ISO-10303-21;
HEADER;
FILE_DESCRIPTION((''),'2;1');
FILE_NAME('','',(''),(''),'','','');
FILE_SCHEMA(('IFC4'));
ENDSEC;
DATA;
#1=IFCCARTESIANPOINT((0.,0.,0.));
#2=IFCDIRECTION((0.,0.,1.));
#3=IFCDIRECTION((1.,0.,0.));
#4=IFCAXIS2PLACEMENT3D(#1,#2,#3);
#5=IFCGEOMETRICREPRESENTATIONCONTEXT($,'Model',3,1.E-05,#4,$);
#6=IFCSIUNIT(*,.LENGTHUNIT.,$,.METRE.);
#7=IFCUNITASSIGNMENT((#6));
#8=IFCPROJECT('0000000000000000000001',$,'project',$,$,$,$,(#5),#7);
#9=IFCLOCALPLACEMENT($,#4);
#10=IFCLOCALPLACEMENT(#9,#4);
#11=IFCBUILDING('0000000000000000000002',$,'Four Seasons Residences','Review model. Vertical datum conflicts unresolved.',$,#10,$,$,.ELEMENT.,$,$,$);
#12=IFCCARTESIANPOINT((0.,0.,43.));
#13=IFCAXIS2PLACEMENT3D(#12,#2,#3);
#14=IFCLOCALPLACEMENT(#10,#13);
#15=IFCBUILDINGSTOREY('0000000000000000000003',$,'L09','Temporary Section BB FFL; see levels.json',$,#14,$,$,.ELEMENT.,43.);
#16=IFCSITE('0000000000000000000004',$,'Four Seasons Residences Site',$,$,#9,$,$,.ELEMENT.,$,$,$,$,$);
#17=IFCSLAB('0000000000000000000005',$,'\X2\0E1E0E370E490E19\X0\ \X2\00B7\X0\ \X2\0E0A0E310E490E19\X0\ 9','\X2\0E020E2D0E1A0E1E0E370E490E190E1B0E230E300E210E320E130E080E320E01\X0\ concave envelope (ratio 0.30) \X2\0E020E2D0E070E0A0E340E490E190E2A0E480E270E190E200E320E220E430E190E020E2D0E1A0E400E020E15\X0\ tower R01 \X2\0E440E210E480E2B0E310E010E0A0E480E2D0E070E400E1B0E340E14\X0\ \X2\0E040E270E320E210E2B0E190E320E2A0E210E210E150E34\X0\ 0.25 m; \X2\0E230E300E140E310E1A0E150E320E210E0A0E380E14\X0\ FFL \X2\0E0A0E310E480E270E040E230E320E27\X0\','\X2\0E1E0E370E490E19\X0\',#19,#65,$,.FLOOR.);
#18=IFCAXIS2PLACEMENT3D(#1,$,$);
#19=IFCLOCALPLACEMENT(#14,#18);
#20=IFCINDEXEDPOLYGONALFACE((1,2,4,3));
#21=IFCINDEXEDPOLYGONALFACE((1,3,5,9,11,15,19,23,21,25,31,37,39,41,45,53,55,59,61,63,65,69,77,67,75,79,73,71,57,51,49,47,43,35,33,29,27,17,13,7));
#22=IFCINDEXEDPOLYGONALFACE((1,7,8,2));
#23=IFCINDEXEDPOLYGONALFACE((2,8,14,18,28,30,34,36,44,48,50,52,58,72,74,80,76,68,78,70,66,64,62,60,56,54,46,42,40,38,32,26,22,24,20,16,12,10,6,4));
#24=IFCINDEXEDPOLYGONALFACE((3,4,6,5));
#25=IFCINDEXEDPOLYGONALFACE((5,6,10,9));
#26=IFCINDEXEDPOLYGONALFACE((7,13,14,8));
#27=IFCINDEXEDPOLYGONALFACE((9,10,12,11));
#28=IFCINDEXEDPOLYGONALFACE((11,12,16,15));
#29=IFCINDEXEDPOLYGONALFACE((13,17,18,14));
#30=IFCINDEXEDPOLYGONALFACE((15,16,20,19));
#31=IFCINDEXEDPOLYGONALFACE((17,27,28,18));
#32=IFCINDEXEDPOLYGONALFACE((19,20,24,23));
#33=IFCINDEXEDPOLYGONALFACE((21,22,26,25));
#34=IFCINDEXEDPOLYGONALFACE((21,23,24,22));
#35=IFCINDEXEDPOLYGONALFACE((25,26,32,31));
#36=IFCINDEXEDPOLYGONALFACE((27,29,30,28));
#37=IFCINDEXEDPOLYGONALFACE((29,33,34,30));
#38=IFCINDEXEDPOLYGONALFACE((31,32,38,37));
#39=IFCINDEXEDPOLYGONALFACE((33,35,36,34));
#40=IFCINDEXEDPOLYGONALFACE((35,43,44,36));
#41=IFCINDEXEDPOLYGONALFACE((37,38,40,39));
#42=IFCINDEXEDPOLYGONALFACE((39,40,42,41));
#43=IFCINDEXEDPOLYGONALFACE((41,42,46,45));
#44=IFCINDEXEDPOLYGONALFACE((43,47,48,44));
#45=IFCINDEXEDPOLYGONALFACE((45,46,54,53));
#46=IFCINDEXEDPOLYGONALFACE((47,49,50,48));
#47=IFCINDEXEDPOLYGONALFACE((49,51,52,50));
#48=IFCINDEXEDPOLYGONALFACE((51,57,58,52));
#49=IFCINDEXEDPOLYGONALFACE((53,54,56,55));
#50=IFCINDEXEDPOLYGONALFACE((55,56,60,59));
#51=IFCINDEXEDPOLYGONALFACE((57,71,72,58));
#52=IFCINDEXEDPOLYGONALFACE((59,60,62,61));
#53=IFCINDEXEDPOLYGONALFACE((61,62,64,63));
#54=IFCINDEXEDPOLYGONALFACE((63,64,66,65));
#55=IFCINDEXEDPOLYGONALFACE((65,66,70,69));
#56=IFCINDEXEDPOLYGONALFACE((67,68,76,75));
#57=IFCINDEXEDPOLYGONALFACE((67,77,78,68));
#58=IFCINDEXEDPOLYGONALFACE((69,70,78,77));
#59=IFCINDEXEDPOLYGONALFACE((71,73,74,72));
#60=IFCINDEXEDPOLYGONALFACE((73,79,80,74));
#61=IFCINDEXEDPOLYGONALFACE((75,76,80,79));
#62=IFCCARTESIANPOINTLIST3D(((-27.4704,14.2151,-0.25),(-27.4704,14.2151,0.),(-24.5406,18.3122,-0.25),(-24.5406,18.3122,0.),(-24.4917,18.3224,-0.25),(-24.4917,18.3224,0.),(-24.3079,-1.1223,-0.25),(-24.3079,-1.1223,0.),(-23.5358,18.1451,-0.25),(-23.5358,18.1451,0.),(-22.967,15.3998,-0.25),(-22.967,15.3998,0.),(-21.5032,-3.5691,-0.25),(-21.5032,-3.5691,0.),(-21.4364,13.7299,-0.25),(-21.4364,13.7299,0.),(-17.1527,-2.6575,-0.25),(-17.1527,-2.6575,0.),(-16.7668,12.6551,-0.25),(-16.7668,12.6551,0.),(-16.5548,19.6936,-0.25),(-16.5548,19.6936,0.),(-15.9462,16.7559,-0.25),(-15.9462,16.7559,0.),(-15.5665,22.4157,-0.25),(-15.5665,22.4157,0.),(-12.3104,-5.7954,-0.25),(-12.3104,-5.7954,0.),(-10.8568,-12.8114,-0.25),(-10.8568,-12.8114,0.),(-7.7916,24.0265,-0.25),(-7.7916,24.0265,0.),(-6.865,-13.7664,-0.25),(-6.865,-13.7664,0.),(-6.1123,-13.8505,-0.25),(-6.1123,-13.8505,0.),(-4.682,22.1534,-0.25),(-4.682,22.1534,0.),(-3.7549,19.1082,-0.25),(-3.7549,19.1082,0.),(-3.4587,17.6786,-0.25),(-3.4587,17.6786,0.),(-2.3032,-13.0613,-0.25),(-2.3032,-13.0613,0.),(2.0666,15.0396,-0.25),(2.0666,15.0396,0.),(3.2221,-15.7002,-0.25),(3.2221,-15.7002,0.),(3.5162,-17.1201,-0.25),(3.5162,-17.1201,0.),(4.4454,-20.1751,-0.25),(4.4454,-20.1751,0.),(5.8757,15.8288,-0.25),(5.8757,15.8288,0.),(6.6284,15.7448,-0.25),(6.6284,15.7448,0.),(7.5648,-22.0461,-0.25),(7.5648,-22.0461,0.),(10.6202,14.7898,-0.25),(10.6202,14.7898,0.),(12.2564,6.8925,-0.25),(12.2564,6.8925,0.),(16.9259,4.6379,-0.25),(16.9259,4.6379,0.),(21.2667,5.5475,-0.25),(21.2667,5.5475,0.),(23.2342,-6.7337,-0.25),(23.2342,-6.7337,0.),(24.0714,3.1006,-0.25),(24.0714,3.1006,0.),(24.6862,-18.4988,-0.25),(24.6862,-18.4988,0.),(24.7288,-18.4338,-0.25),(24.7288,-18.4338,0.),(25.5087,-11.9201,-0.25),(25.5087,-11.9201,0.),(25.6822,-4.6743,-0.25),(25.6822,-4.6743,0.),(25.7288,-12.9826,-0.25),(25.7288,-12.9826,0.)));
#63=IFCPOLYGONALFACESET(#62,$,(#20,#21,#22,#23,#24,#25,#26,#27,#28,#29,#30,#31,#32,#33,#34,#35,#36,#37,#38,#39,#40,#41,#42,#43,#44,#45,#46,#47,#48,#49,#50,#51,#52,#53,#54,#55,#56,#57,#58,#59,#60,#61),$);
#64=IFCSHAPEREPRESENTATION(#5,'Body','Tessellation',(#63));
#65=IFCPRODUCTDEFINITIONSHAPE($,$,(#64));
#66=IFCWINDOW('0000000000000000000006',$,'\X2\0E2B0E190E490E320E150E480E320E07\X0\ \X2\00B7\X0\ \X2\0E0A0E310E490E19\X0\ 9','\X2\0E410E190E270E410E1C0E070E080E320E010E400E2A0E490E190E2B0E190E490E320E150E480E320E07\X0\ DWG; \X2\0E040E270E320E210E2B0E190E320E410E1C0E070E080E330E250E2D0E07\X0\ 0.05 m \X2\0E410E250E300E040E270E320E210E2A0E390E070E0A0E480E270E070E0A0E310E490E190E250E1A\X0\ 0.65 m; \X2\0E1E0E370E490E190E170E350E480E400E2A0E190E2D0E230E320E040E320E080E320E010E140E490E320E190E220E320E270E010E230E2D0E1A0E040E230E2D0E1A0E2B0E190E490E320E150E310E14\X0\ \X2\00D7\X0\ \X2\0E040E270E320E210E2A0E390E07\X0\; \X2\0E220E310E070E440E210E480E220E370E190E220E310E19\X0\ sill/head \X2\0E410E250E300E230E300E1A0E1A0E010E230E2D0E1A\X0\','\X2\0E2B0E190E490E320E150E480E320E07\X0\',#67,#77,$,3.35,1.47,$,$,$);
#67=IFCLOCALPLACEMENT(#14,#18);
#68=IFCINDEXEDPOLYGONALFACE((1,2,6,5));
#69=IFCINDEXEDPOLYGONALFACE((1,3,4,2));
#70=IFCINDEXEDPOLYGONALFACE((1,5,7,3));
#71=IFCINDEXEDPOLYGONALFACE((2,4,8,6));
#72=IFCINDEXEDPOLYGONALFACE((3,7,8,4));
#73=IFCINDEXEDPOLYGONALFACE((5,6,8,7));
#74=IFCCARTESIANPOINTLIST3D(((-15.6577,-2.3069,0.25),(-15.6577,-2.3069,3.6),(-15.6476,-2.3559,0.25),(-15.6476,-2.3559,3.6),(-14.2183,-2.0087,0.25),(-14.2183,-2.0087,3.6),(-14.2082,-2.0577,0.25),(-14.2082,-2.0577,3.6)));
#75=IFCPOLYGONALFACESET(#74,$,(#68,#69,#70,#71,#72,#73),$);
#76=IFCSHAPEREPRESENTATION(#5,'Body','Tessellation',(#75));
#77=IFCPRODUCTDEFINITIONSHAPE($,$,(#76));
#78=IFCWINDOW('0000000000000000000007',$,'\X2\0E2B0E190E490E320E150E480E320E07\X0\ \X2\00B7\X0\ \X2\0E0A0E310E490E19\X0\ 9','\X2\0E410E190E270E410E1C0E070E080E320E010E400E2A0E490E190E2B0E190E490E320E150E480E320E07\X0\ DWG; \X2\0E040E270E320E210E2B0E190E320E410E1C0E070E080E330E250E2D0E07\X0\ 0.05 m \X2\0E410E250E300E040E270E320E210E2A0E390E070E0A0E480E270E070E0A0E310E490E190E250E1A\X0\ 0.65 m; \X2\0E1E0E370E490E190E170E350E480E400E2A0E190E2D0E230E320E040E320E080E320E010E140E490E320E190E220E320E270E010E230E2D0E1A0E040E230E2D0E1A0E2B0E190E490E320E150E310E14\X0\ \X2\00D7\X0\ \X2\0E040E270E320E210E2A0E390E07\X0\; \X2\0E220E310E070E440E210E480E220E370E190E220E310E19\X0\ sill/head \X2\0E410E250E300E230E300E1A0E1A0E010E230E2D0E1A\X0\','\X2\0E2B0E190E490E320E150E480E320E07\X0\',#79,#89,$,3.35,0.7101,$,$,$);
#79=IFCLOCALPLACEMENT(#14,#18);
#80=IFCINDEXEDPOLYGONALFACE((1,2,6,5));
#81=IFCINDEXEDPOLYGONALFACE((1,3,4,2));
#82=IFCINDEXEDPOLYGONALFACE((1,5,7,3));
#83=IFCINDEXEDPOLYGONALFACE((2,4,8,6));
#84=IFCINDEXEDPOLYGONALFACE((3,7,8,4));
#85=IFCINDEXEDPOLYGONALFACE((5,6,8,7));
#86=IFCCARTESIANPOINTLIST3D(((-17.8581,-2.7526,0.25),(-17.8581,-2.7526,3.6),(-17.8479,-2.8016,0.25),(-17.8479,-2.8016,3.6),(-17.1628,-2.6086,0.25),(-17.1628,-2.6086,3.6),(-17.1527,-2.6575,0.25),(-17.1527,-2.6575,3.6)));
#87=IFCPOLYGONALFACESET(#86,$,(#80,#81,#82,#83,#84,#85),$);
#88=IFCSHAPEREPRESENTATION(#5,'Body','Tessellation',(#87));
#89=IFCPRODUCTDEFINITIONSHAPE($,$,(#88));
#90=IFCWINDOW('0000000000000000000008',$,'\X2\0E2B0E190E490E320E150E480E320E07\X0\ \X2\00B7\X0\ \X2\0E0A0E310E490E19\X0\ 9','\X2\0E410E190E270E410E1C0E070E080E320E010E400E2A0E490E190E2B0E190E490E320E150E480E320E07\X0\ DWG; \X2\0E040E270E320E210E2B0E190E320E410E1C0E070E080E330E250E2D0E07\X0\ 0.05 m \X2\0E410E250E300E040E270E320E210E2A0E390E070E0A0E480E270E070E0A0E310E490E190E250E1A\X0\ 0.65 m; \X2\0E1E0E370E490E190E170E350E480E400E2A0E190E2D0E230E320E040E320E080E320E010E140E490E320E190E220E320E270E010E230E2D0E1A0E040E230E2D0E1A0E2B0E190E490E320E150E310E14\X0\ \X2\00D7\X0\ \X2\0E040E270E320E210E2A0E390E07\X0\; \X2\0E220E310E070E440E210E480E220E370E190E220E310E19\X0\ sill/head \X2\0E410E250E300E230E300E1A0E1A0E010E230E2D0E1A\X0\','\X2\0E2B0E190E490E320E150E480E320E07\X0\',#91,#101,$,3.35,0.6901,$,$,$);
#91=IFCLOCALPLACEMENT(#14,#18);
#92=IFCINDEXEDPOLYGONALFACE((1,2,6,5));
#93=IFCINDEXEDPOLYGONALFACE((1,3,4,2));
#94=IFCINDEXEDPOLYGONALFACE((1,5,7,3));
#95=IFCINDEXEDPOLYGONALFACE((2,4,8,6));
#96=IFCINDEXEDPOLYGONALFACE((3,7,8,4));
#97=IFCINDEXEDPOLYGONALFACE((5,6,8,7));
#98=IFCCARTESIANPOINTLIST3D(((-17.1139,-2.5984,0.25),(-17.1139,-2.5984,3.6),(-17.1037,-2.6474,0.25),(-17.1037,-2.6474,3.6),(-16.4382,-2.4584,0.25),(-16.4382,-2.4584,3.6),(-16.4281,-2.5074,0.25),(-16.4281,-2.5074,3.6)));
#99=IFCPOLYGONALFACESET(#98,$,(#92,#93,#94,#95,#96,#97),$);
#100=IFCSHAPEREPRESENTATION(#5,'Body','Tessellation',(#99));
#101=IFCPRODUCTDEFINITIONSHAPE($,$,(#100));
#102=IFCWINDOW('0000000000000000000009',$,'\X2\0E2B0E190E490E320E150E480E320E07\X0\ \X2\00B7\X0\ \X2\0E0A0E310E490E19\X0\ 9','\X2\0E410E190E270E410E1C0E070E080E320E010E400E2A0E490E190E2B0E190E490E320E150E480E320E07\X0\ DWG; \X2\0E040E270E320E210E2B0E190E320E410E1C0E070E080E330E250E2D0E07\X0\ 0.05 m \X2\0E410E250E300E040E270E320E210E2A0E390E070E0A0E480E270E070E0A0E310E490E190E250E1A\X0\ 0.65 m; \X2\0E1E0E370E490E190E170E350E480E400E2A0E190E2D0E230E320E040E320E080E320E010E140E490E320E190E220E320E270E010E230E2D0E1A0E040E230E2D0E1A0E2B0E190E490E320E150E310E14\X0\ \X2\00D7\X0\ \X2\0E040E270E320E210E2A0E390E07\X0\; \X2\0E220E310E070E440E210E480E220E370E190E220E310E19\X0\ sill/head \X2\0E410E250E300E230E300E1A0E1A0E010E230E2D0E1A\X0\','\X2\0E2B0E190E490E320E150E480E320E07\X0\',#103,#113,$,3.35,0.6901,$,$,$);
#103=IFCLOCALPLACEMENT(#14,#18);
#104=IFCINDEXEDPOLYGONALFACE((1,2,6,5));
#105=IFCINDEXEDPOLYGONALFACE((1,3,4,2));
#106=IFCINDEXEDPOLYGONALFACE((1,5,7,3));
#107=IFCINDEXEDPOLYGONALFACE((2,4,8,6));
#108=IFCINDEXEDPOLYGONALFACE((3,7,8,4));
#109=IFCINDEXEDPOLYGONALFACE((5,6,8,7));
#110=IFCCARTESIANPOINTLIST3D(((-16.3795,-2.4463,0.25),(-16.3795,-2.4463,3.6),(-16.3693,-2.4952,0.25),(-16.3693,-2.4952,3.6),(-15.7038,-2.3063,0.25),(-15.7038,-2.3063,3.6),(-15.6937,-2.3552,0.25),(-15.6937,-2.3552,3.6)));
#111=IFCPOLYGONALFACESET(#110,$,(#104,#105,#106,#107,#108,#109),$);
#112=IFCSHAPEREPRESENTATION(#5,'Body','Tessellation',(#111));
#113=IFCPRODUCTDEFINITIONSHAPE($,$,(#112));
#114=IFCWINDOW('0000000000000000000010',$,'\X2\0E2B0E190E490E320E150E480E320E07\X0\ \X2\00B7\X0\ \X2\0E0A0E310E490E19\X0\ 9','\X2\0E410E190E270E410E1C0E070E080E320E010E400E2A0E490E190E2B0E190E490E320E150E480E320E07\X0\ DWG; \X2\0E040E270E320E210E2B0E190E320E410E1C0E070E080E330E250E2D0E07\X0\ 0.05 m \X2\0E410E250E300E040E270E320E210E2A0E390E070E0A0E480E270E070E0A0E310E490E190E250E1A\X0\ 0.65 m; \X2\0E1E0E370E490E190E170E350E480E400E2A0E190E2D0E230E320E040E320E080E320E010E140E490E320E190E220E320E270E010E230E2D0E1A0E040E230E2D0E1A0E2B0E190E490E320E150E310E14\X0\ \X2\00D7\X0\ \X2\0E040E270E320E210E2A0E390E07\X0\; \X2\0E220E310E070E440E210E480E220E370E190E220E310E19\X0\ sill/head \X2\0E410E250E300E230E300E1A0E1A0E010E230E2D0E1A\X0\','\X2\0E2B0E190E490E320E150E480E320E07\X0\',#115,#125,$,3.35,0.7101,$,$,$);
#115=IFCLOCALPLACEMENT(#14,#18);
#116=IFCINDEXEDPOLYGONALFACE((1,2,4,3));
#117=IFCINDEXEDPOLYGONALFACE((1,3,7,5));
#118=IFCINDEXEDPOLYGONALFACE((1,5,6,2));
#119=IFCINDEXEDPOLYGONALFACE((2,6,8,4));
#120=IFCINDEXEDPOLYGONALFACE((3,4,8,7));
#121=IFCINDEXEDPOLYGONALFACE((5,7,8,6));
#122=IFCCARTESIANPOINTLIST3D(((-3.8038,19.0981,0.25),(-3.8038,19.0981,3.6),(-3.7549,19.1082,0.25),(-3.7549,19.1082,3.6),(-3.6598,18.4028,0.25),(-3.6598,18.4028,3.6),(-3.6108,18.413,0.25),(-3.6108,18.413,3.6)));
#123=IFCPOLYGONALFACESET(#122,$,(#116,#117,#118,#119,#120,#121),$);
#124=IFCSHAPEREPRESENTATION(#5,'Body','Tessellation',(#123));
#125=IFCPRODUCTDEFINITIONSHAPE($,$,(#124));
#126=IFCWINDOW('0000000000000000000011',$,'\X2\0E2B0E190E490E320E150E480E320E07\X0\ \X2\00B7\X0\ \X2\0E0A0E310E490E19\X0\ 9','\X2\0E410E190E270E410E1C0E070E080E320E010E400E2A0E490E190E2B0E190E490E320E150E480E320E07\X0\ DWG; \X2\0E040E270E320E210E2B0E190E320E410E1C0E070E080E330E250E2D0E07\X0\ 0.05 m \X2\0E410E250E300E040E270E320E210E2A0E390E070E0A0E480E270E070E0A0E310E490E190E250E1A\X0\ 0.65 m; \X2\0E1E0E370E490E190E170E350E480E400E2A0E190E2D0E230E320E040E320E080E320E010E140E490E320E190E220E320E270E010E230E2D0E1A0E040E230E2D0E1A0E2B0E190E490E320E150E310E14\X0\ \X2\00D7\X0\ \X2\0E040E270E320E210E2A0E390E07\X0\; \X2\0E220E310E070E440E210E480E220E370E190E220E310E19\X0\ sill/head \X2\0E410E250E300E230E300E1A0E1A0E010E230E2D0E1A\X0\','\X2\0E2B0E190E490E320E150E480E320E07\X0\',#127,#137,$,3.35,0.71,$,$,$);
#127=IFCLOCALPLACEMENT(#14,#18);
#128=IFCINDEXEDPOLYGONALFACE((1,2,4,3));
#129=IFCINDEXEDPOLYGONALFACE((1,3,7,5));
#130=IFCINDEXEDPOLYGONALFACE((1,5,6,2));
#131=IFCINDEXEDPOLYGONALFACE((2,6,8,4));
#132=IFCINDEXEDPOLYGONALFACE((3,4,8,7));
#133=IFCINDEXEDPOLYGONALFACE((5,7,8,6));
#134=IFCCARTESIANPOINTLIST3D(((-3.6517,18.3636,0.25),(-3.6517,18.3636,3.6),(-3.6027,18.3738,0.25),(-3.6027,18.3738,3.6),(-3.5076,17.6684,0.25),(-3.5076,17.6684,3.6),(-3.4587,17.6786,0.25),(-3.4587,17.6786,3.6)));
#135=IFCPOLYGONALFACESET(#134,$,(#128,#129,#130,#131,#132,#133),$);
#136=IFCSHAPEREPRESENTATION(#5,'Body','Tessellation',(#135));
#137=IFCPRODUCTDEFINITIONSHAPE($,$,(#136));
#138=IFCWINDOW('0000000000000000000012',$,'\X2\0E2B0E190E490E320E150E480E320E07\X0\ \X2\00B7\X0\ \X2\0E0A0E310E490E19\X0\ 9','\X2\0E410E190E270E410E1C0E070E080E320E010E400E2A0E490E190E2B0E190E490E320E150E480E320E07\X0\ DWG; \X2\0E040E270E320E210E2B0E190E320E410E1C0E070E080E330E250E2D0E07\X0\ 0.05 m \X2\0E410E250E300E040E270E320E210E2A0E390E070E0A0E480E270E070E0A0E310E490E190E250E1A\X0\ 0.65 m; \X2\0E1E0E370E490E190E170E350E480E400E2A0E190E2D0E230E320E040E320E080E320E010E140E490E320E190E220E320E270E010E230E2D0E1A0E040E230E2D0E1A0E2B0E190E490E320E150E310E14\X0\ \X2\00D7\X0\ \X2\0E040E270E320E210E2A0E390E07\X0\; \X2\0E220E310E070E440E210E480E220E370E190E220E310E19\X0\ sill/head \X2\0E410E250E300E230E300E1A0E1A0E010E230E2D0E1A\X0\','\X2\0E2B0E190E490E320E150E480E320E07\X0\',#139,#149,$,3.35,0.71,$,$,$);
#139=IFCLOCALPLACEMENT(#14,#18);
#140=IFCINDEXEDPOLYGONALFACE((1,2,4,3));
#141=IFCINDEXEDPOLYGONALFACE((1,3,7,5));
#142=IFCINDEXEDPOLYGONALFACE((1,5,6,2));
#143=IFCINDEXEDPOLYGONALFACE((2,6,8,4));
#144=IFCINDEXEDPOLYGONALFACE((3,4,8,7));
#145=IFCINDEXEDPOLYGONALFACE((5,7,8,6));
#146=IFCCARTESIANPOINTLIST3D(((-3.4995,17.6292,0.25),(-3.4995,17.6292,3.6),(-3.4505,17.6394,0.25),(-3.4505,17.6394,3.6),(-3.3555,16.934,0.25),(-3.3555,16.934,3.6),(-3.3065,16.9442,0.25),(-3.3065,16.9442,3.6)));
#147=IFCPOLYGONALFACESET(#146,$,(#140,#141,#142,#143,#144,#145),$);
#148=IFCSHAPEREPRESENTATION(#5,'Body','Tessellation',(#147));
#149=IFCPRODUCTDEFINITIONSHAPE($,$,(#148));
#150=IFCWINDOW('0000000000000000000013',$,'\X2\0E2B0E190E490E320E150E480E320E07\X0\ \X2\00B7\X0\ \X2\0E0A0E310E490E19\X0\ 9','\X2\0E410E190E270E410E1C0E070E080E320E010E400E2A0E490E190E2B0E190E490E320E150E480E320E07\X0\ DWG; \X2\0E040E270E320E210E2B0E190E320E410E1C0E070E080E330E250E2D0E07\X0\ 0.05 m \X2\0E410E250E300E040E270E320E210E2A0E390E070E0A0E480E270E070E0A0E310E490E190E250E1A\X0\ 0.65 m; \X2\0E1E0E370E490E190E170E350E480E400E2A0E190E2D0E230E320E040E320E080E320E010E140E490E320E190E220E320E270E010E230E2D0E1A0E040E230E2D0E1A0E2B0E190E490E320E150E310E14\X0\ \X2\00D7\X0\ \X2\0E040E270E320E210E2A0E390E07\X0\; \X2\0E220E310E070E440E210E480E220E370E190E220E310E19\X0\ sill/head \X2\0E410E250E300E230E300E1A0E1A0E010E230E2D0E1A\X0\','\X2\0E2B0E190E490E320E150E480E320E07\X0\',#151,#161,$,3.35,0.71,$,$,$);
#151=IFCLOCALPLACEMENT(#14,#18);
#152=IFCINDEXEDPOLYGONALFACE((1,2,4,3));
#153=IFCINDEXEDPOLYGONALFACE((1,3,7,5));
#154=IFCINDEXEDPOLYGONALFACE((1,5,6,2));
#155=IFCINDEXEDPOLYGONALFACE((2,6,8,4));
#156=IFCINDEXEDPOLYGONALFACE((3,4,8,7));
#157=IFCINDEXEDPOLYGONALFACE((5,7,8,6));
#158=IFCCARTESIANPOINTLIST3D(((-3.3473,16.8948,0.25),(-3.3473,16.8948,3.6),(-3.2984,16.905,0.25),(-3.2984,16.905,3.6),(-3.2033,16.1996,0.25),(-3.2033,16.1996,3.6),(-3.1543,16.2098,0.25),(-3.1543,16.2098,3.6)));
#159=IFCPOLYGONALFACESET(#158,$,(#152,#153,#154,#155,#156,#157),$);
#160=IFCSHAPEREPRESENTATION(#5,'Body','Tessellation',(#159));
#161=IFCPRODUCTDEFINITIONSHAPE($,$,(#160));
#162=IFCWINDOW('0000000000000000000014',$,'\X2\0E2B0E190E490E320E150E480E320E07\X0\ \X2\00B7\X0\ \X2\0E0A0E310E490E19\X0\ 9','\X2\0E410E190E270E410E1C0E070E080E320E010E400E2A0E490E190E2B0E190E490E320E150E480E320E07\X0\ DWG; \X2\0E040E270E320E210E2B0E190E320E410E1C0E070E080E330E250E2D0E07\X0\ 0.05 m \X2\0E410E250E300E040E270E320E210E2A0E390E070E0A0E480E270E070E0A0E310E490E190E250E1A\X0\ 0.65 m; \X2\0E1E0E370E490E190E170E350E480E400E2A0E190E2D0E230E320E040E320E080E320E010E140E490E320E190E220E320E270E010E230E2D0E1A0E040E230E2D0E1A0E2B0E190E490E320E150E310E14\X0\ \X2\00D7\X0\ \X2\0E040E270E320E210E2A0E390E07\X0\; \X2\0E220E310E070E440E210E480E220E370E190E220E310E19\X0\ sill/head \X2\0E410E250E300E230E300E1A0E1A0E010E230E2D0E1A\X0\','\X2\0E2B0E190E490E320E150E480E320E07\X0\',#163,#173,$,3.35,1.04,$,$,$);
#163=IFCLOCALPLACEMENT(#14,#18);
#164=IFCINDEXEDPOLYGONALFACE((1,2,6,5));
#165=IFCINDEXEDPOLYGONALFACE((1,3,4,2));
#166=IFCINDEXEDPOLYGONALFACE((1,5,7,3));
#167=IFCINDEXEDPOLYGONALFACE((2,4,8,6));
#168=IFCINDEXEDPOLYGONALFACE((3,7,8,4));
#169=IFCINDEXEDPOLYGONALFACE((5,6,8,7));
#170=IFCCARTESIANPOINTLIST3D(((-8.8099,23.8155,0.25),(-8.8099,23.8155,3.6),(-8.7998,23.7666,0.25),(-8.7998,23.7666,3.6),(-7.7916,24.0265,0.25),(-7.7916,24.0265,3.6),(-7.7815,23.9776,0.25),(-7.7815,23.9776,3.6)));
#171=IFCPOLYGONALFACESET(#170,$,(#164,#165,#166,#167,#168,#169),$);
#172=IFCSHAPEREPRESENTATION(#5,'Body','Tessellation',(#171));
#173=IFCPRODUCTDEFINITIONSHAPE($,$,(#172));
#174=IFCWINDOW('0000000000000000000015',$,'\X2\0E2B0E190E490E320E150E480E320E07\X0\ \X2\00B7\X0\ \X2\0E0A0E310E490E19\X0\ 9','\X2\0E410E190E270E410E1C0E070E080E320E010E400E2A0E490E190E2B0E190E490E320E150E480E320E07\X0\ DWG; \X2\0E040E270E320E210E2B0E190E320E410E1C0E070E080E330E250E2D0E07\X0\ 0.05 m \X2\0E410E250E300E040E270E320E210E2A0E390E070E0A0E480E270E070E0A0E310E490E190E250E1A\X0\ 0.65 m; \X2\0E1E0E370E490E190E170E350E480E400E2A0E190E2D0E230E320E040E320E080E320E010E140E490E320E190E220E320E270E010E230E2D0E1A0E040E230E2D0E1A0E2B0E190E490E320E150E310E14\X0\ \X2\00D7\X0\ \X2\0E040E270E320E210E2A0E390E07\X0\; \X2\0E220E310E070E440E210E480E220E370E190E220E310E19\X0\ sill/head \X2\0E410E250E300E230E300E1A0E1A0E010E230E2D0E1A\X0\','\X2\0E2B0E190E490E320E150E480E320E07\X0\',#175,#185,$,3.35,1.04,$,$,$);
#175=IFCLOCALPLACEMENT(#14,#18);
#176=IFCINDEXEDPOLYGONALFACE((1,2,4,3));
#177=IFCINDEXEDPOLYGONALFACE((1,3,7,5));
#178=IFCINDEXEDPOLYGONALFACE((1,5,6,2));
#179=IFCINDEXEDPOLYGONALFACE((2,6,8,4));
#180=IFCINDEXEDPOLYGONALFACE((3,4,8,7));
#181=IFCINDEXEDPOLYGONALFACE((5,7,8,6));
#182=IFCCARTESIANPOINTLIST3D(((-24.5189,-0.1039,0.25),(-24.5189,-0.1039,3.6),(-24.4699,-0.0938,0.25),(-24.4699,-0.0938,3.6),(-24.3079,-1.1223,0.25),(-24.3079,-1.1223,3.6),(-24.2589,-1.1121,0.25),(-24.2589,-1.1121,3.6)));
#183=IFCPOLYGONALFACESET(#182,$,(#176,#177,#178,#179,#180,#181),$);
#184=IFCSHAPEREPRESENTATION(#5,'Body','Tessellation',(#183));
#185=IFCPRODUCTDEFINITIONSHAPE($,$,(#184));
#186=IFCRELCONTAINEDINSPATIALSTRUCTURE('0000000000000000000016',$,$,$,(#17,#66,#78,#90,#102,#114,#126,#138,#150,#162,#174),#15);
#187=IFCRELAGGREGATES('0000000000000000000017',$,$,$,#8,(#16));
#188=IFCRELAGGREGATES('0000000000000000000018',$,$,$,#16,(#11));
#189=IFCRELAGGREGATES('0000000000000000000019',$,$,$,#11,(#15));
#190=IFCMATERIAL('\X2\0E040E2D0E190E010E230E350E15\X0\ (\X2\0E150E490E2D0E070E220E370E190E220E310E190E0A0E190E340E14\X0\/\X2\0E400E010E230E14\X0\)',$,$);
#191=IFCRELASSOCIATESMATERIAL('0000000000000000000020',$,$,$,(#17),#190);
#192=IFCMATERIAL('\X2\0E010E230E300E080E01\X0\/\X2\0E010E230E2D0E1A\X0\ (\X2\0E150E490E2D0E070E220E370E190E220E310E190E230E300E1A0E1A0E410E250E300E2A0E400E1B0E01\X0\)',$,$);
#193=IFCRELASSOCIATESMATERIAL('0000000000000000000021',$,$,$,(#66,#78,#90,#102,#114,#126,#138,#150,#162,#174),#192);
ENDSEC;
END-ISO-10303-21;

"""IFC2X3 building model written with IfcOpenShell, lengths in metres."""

from ifc_helpers import new_model, si_unit, frame, origin_with_axes, place, context, project, spatial, polyline, outline, extrude, material, element, save


model = new_model("IFC2X3")

# Units and contexts
model_context = context("Model", 3, precision=1e-05, world=origin_with_axes())
ifc_project = project(units=[si_unit("LENGTHUNIT", "METRE")], contexts=[model_context])

# Site, building, storey
site_placement = place(None, origin_with_axes())
site = spatial("IfcSite", under=ifc_project, at=site_placement, Name="Four Seasons Residences Site", CompositionType="ELEMENT")
building_placement = place(site_placement, origin_with_axes())
building = spatial("IfcBuilding", under=site, at=building_placement, Name="Four Seasons Residences", Description="Review model. Vertical datum conflicts unresolved.", CompositionType="ELEMENT")
storey_placement = place(building_placement, frame((0.0, 0.0, 43.0), z_axis=(0.0, 0.0, 1.0), x_axis=(1.0, 0.0, 0.0)))
storey = spatial("IfcBuildingStorey", under=building, at=storey_placement, Name="L09", Description="Temporary Section BB FFL; see levels.json", CompositionType="ELEMENT", Elevation=43.0)

# Slab
ifc_material_1 = material(Name="คอนกรีต (ต้องยืนยันชนิด/เกรด)")
slab_placement = place(storey_placement, origin_with_axes())
element("IfcSlab", 1, at=slab_placement, inside=storey, material=ifc_material_1, Name="พื้น · ชั้น 9", Description="ขอบพื้นประมาณจาก concave envelope (ratio 0.30) ของชิ้นส่วนภายในขอบเขต tower R01 ไม่หักช่องเปิด ความหนาสมมติ 0.25 m; ระดับตามชุด FFL ชั่วคราว", ObjectType="พื้น", PredefinedType="FLOOR", context=model_context, shape_type="SweptSolid", body=[
    extrude(outline(polyline([(-27.4704, 14.2151), (-24.5406, 18.3122), (-24.4917, 18.3224), (-23.5358, 18.1451), (-22.967, 15.3998), (-21.4364, 13.7299), (-16.7668, 12.6551), (-15.9462, 16.7559), (-16.5548, 19.6936), (-15.5665, 22.4157), (-7.7916, 24.0265), (-4.682, 22.1534), (-3.7549, 19.1082), (-3.4587, 17.6786), (2.0666, 15.0396), (5.8757, 15.8288), (6.6284, 15.7448), (10.6202, 14.7898), (12.2564, 6.8925), (16.9259, 4.6379), (21.2667, 5.5475), (24.0714, 3.1006), (25.6822, -4.6743), (23.2342, -6.7337), (25.5087, -11.9201), (25.7288, -12.9826), (24.7288, -18.4338), (24.6862, -18.4988), (7.5648, -22.0461), (4.4454, -20.1751), (3.5162, -17.1201), (3.2221, -15.7002), (-2.3032, -13.0613), (-6.1123, -13.8505), (-6.865, -13.7664), (-10.8568, -12.8114), (-12.3104, -5.7954), (-17.1527, -2.6575), (-21.5032, -3.5691), (-24.3079, -1.1223), (-27.4704, 14.2151)])), frame((0.0, 0.0, -0.25), z_axis=(0.0, 0.0, 1.0), x_axis=(1.0, 0.0, 0.0)), (0.0, 0.0, 1.0), 0.25),
])

# Windows
ifc_material_2 = material(Name="กระจก/กรอบ (ต้องยืนยันระบบและสเปก)")
window_1_placement = place(storey_placement, origin_with_axes())
element("IfcWindow", 2, at=window_1_placement, inside=storey, material=ifc_material_2, Name="หน้าต่าง · ชั้น 9", Description="แนวแผงจากเส้นหน้าต่าง DWG; ความหนาแผงจำลอง 0.05 m และความสูงช่วงชั้นลบ 0.65 m; พื้นที่เสนอราคาจากด้านยาวกรอบครอบหน้าตัด × ความสูง; ยังไม่ยืนยัน sill/head และระบบกรอบ", ObjectType="หน้าต่าง", OverallHeight=3.35, OverallWidth=1.47, context=model_context, shape_type="SweptSolid", body=[
    extrude(outline(polyline([(-14.2183, -2.0087), (-14.2082, -2.0577), (-15.6476, -2.3559), (-15.6577, -2.3069), (-14.2183, -2.0087)])), frame((0.0, 0.0, 0.25), z_axis=(0.0, 0.0, 1.0), x_axis=(1.0, 0.0, 0.0)), (0.0, 0.0, 1.0), 3.35),
])
window_2_placement = place(storey_placement, origin_with_axes())
element("IfcWindow", 3, at=window_2_placement, inside=storey, material=ifc_material_2, Name="หน้าต่าง · ชั้น 9", Description="แนวแผงจากเส้นหน้าต่าง DWG; ความหนาแผงจำลอง 0.05 m และความสูงช่วงชั้นลบ 0.65 m; พื้นที่เสนอราคาจากด้านยาวกรอบครอบหน้าตัด × ความสูง; ยังไม่ยืนยัน sill/head และระบบกรอบ", ObjectType="หน้าต่าง", OverallHeight=3.35, OverallWidth=0.7101, context=model_context, shape_type="SweptSolid", body=[
    extrude(outline(polyline([(-17.1628, -2.6086), (-17.1527, -2.6575), (-17.8479, -2.8016), (-17.8581, -2.7526), (-17.1628, -2.6086)])), frame((0.0, 0.0, 0.25), z_axis=(0.0, 0.0, 1.0), x_axis=(1.0, 0.0, 0.0)), (0.0, 0.0, 1.0), 3.35),
])
window_3_placement = place(storey_placement, origin_with_axes())
element("IfcWindow", 4, at=window_3_placement, inside=storey, material=ifc_material_2, Name="หน้าต่าง · ชั้น 9", Description="แนวแผงจากเส้นหน้าต่าง DWG; ความหนาแผงจำลอง 0.05 m และความสูงช่วงชั้นลบ 0.65 m; พื้นที่เสนอราคาจากด้านยาวกรอบครอบหน้าตัด × ความสูง; ยังไม่ยืนยัน sill/head และระบบกรอบ", ObjectType="หน้าต่าง", OverallHeight=3.35, OverallWidth=0.6901, context=model_context, shape_type="SweptSolid", body=[
    extrude(outline(polyline([(-16.4382, -2.4584), (-16.4281, -2.5074), (-17.1037, -2.6474), (-17.1139, -2.5984), (-16.4382, -2.4584)])), frame((0.0, 0.0, 0.25), z_axis=(0.0, 0.0, 1.0), x_axis=(1.0, 0.0, 0.0)), (0.0, 0.0, 1.0), 3.35),
])
window_4_placement = place(storey_placement, origin_with_axes())
element("IfcWindow", 5, at=window_4_placement, inside=storey, material=ifc_material_2, Name="หน้าต่าง · ชั้น 9", Description="แนวแผงจากเส้นหน้าต่าง DWG; ความหนาแผงจำลอง 0.05 m และความสูงช่วงชั้นลบ 0.65 m; พื้นที่เสนอราคาจากด้านยาวกรอบครอบหน้าตัด × ความสูง; ยังไม่ยืนยัน sill/head และระบบกรอบ", ObjectType="หน้าต่าง", OverallHeight=3.35, OverallWidth=0.6901, context=model_context, shape_type="SweptSolid", body=[
    extrude(outline(polyline([(-15.7038, -2.3063), (-15.6937, -2.3552), (-16.3693, -2.4952), (-16.3795, -2.4463), (-15.7038, -2.3063)])), frame((0.0, 0.0, 0.25), z_axis=(0.0, 0.0, 1.0), x_axis=(1.0, 0.0, 0.0)), (0.0, 0.0, 1.0), 3.35),
])
window_5_placement = place(storey_placement, origin_with_axes())
element("IfcWindow", 6, at=window_5_placement, inside=storey, material=ifc_material_2, Name="หน้าต่าง · ชั้น 9", Description="แนวแผงจากเส้นหน้าต่าง DWG; ความหนาแผงจำลอง 0.05 m และความสูงช่วงชั้นลบ 0.65 m; พื้นที่เสนอราคาจากด้านยาวกรอบครอบหน้าตัด × ความสูง; ยังไม่ยืนยัน sill/head และระบบกรอบ", ObjectType="หน้าต่าง", OverallHeight=3.35, OverallWidth=0.7101, context=model_context, shape_type="SweptSolid", body=[
    extrude(outline(polyline([(-3.6108, 18.413), (-3.6598, 18.4028), (-3.8038, 19.0981), (-3.7549, 19.1082), (-3.6108, 18.413)])), frame((0.0, 0.0, 0.25), z_axis=(0.0, 0.0, 1.0), x_axis=(1.0, 0.0, 0.0)), (0.0, 0.0, 1.0), 3.35),
])
window_6_placement = place(storey_placement, origin_with_axes())
element("IfcWindow", 7, at=window_6_placement, inside=storey, material=ifc_material_2, Name="หน้าต่าง · ชั้น 9", Description="แนวแผงจากเส้นหน้าต่าง DWG; ความหนาแผงจำลอง 0.05 m และความสูงช่วงชั้นลบ 0.65 m; พื้นที่เสนอราคาจากด้านยาวกรอบครอบหน้าตัด × ความสูง; ยังไม่ยืนยัน sill/head และระบบกรอบ", ObjectType="หน้าต่าง", OverallHeight=3.35, OverallWidth=0.71, context=model_context, shape_type="SweptSolid", body=[
    extrude(outline(polyline([(-3.4587, 17.6786), (-3.5076, 17.6684), (-3.6517, 18.3636), (-3.6027, 18.3738), (-3.4587, 17.6786)])), frame((0.0, 0.0, 0.25), z_axis=(0.0, 0.0, 1.0), x_axis=(1.0, 0.0, 0.0)), (0.0, 0.0, 1.0), 3.35),
])
window_7_placement = place(storey_placement, origin_with_axes())
element("IfcWindow", 8, at=window_7_placement, inside=storey, material=ifc_material_2, Name="หน้าต่าง · ชั้น 9", Description="แนวแผงจากเส้นหน้าต่าง DWG; ความหนาแผงจำลอง 0.05 m และความสูงช่วงชั้นลบ 0.65 m; พื้นที่เสนอราคาจากด้านยาวกรอบครอบหน้าตัด × ความสูง; ยังไม่ยืนยัน sill/head และระบบกรอบ", ObjectType="หน้าต่าง", OverallHeight=3.35, OverallWidth=0.71, context=model_context, shape_type="SweptSolid", body=[
    extrude(outline(polyline([(-3.3065, 16.9442), (-3.3555, 16.934), (-3.4995, 17.6292), (-3.4505, 17.6394), (-3.3065, 16.9442)])), frame((0.0, 0.0, 0.25), z_axis=(0.0, 0.0, 1.0), x_axis=(1.0, 0.0, 0.0)), (0.0, 0.0, 1.0), 3.35),
])
window_8_placement = place(storey_placement, origin_with_axes())
element("IfcWindow", 9, at=window_8_placement, inside=storey, material=ifc_material_2, Name="หน้าต่าง · ชั้น 9", Description="แนวแผงจากเส้นหน้าต่าง DWG; ความหนาแผงจำลอง 0.05 m และความสูงช่วงชั้นลบ 0.65 m; พื้นที่เสนอราคาจากด้านยาวกรอบครอบหน้าตัด × ความสูง; ยังไม่ยืนยัน sill/head และระบบกรอบ", ObjectType="หน้าต่าง", OverallHeight=3.35, OverallWidth=0.71, context=model_context, shape_type="SweptSolid", body=[
    extrude(outline(polyline([(-3.1543, 16.2098), (-3.2033, 16.1996), (-3.3473, 16.8948), (-3.2984, 16.905), (-3.1543, 16.2098)])), frame((0.0, 0.0, 0.25), z_axis=(0.0, 0.0, 1.0), x_axis=(1.0, 0.0, 0.0)), (0.0, 0.0, 1.0), 3.35),
])
window_9_placement = place(storey_placement, origin_with_axes())
element("IfcWindow", 10, at=window_9_placement, inside=storey, material=ifc_material_2, Name="หน้าต่าง · ชั้น 9", Description="แนวแผงจากเส้นหน้าต่าง DWG; ความหนาแผงจำลอง 0.05 m และความสูงช่วงชั้นลบ 0.65 m; พื้นที่เสนอราคาจากด้านยาวกรอบครอบหน้าตัด × ความสูง; ยังไม่ยืนยัน sill/head และระบบกรอบ", ObjectType="หน้าต่าง", OverallHeight=3.35, OverallWidth=1.04, context=model_context, shape_type="SweptSolid", body=[
    extrude(outline(polyline([(-7.7916, 24.0265), (-7.7815, 23.9776), (-8.7998, 23.7666), (-8.8099, 23.8155), (-7.7916, 24.0265)])), frame((0.0, 0.0, 0.25), z_axis=(0.0, 0.0, 1.0), x_axis=(1.0, 0.0, 0.0)), (0.0, 0.0, 1.0), 3.35),
])
window_10_placement = place(storey_placement, origin_with_axes())
element("IfcWindow", 11, at=window_10_placement, inside=storey, material=ifc_material_2, Name="หน้าต่าง · ชั้น 9", Description="แนวแผงจากเส้นหน้าต่าง DWG; ความหนาแผงจำลอง 0.05 m และความสูงช่วงชั้นลบ 0.65 m; พื้นที่เสนอราคาจากด้านยาวกรอบครอบหน้าตัด × ความสูง; ยังไม่ยืนยัน sill/head และระบบกรอบ", ObjectType="หน้าต่าง", OverallHeight=3.35, OverallWidth=1.04, context=model_context, shape_type="SweptSolid", body=[
    extrude(outline(polyline([(-24.2589, -1.1121), (-24.3079, -1.1223), (-24.5189, -0.1039), (-24.4699, -0.0938), (-24.2589, -1.1121)])), frame((0.0, 0.0, 0.25), z_axis=(0.0, 0.0, 1.0), x_axis=(1.0, 0.0, 0.0)), (0.0, 0.0, 1.0), 3.35),
])

save(model, "model.ifc")
